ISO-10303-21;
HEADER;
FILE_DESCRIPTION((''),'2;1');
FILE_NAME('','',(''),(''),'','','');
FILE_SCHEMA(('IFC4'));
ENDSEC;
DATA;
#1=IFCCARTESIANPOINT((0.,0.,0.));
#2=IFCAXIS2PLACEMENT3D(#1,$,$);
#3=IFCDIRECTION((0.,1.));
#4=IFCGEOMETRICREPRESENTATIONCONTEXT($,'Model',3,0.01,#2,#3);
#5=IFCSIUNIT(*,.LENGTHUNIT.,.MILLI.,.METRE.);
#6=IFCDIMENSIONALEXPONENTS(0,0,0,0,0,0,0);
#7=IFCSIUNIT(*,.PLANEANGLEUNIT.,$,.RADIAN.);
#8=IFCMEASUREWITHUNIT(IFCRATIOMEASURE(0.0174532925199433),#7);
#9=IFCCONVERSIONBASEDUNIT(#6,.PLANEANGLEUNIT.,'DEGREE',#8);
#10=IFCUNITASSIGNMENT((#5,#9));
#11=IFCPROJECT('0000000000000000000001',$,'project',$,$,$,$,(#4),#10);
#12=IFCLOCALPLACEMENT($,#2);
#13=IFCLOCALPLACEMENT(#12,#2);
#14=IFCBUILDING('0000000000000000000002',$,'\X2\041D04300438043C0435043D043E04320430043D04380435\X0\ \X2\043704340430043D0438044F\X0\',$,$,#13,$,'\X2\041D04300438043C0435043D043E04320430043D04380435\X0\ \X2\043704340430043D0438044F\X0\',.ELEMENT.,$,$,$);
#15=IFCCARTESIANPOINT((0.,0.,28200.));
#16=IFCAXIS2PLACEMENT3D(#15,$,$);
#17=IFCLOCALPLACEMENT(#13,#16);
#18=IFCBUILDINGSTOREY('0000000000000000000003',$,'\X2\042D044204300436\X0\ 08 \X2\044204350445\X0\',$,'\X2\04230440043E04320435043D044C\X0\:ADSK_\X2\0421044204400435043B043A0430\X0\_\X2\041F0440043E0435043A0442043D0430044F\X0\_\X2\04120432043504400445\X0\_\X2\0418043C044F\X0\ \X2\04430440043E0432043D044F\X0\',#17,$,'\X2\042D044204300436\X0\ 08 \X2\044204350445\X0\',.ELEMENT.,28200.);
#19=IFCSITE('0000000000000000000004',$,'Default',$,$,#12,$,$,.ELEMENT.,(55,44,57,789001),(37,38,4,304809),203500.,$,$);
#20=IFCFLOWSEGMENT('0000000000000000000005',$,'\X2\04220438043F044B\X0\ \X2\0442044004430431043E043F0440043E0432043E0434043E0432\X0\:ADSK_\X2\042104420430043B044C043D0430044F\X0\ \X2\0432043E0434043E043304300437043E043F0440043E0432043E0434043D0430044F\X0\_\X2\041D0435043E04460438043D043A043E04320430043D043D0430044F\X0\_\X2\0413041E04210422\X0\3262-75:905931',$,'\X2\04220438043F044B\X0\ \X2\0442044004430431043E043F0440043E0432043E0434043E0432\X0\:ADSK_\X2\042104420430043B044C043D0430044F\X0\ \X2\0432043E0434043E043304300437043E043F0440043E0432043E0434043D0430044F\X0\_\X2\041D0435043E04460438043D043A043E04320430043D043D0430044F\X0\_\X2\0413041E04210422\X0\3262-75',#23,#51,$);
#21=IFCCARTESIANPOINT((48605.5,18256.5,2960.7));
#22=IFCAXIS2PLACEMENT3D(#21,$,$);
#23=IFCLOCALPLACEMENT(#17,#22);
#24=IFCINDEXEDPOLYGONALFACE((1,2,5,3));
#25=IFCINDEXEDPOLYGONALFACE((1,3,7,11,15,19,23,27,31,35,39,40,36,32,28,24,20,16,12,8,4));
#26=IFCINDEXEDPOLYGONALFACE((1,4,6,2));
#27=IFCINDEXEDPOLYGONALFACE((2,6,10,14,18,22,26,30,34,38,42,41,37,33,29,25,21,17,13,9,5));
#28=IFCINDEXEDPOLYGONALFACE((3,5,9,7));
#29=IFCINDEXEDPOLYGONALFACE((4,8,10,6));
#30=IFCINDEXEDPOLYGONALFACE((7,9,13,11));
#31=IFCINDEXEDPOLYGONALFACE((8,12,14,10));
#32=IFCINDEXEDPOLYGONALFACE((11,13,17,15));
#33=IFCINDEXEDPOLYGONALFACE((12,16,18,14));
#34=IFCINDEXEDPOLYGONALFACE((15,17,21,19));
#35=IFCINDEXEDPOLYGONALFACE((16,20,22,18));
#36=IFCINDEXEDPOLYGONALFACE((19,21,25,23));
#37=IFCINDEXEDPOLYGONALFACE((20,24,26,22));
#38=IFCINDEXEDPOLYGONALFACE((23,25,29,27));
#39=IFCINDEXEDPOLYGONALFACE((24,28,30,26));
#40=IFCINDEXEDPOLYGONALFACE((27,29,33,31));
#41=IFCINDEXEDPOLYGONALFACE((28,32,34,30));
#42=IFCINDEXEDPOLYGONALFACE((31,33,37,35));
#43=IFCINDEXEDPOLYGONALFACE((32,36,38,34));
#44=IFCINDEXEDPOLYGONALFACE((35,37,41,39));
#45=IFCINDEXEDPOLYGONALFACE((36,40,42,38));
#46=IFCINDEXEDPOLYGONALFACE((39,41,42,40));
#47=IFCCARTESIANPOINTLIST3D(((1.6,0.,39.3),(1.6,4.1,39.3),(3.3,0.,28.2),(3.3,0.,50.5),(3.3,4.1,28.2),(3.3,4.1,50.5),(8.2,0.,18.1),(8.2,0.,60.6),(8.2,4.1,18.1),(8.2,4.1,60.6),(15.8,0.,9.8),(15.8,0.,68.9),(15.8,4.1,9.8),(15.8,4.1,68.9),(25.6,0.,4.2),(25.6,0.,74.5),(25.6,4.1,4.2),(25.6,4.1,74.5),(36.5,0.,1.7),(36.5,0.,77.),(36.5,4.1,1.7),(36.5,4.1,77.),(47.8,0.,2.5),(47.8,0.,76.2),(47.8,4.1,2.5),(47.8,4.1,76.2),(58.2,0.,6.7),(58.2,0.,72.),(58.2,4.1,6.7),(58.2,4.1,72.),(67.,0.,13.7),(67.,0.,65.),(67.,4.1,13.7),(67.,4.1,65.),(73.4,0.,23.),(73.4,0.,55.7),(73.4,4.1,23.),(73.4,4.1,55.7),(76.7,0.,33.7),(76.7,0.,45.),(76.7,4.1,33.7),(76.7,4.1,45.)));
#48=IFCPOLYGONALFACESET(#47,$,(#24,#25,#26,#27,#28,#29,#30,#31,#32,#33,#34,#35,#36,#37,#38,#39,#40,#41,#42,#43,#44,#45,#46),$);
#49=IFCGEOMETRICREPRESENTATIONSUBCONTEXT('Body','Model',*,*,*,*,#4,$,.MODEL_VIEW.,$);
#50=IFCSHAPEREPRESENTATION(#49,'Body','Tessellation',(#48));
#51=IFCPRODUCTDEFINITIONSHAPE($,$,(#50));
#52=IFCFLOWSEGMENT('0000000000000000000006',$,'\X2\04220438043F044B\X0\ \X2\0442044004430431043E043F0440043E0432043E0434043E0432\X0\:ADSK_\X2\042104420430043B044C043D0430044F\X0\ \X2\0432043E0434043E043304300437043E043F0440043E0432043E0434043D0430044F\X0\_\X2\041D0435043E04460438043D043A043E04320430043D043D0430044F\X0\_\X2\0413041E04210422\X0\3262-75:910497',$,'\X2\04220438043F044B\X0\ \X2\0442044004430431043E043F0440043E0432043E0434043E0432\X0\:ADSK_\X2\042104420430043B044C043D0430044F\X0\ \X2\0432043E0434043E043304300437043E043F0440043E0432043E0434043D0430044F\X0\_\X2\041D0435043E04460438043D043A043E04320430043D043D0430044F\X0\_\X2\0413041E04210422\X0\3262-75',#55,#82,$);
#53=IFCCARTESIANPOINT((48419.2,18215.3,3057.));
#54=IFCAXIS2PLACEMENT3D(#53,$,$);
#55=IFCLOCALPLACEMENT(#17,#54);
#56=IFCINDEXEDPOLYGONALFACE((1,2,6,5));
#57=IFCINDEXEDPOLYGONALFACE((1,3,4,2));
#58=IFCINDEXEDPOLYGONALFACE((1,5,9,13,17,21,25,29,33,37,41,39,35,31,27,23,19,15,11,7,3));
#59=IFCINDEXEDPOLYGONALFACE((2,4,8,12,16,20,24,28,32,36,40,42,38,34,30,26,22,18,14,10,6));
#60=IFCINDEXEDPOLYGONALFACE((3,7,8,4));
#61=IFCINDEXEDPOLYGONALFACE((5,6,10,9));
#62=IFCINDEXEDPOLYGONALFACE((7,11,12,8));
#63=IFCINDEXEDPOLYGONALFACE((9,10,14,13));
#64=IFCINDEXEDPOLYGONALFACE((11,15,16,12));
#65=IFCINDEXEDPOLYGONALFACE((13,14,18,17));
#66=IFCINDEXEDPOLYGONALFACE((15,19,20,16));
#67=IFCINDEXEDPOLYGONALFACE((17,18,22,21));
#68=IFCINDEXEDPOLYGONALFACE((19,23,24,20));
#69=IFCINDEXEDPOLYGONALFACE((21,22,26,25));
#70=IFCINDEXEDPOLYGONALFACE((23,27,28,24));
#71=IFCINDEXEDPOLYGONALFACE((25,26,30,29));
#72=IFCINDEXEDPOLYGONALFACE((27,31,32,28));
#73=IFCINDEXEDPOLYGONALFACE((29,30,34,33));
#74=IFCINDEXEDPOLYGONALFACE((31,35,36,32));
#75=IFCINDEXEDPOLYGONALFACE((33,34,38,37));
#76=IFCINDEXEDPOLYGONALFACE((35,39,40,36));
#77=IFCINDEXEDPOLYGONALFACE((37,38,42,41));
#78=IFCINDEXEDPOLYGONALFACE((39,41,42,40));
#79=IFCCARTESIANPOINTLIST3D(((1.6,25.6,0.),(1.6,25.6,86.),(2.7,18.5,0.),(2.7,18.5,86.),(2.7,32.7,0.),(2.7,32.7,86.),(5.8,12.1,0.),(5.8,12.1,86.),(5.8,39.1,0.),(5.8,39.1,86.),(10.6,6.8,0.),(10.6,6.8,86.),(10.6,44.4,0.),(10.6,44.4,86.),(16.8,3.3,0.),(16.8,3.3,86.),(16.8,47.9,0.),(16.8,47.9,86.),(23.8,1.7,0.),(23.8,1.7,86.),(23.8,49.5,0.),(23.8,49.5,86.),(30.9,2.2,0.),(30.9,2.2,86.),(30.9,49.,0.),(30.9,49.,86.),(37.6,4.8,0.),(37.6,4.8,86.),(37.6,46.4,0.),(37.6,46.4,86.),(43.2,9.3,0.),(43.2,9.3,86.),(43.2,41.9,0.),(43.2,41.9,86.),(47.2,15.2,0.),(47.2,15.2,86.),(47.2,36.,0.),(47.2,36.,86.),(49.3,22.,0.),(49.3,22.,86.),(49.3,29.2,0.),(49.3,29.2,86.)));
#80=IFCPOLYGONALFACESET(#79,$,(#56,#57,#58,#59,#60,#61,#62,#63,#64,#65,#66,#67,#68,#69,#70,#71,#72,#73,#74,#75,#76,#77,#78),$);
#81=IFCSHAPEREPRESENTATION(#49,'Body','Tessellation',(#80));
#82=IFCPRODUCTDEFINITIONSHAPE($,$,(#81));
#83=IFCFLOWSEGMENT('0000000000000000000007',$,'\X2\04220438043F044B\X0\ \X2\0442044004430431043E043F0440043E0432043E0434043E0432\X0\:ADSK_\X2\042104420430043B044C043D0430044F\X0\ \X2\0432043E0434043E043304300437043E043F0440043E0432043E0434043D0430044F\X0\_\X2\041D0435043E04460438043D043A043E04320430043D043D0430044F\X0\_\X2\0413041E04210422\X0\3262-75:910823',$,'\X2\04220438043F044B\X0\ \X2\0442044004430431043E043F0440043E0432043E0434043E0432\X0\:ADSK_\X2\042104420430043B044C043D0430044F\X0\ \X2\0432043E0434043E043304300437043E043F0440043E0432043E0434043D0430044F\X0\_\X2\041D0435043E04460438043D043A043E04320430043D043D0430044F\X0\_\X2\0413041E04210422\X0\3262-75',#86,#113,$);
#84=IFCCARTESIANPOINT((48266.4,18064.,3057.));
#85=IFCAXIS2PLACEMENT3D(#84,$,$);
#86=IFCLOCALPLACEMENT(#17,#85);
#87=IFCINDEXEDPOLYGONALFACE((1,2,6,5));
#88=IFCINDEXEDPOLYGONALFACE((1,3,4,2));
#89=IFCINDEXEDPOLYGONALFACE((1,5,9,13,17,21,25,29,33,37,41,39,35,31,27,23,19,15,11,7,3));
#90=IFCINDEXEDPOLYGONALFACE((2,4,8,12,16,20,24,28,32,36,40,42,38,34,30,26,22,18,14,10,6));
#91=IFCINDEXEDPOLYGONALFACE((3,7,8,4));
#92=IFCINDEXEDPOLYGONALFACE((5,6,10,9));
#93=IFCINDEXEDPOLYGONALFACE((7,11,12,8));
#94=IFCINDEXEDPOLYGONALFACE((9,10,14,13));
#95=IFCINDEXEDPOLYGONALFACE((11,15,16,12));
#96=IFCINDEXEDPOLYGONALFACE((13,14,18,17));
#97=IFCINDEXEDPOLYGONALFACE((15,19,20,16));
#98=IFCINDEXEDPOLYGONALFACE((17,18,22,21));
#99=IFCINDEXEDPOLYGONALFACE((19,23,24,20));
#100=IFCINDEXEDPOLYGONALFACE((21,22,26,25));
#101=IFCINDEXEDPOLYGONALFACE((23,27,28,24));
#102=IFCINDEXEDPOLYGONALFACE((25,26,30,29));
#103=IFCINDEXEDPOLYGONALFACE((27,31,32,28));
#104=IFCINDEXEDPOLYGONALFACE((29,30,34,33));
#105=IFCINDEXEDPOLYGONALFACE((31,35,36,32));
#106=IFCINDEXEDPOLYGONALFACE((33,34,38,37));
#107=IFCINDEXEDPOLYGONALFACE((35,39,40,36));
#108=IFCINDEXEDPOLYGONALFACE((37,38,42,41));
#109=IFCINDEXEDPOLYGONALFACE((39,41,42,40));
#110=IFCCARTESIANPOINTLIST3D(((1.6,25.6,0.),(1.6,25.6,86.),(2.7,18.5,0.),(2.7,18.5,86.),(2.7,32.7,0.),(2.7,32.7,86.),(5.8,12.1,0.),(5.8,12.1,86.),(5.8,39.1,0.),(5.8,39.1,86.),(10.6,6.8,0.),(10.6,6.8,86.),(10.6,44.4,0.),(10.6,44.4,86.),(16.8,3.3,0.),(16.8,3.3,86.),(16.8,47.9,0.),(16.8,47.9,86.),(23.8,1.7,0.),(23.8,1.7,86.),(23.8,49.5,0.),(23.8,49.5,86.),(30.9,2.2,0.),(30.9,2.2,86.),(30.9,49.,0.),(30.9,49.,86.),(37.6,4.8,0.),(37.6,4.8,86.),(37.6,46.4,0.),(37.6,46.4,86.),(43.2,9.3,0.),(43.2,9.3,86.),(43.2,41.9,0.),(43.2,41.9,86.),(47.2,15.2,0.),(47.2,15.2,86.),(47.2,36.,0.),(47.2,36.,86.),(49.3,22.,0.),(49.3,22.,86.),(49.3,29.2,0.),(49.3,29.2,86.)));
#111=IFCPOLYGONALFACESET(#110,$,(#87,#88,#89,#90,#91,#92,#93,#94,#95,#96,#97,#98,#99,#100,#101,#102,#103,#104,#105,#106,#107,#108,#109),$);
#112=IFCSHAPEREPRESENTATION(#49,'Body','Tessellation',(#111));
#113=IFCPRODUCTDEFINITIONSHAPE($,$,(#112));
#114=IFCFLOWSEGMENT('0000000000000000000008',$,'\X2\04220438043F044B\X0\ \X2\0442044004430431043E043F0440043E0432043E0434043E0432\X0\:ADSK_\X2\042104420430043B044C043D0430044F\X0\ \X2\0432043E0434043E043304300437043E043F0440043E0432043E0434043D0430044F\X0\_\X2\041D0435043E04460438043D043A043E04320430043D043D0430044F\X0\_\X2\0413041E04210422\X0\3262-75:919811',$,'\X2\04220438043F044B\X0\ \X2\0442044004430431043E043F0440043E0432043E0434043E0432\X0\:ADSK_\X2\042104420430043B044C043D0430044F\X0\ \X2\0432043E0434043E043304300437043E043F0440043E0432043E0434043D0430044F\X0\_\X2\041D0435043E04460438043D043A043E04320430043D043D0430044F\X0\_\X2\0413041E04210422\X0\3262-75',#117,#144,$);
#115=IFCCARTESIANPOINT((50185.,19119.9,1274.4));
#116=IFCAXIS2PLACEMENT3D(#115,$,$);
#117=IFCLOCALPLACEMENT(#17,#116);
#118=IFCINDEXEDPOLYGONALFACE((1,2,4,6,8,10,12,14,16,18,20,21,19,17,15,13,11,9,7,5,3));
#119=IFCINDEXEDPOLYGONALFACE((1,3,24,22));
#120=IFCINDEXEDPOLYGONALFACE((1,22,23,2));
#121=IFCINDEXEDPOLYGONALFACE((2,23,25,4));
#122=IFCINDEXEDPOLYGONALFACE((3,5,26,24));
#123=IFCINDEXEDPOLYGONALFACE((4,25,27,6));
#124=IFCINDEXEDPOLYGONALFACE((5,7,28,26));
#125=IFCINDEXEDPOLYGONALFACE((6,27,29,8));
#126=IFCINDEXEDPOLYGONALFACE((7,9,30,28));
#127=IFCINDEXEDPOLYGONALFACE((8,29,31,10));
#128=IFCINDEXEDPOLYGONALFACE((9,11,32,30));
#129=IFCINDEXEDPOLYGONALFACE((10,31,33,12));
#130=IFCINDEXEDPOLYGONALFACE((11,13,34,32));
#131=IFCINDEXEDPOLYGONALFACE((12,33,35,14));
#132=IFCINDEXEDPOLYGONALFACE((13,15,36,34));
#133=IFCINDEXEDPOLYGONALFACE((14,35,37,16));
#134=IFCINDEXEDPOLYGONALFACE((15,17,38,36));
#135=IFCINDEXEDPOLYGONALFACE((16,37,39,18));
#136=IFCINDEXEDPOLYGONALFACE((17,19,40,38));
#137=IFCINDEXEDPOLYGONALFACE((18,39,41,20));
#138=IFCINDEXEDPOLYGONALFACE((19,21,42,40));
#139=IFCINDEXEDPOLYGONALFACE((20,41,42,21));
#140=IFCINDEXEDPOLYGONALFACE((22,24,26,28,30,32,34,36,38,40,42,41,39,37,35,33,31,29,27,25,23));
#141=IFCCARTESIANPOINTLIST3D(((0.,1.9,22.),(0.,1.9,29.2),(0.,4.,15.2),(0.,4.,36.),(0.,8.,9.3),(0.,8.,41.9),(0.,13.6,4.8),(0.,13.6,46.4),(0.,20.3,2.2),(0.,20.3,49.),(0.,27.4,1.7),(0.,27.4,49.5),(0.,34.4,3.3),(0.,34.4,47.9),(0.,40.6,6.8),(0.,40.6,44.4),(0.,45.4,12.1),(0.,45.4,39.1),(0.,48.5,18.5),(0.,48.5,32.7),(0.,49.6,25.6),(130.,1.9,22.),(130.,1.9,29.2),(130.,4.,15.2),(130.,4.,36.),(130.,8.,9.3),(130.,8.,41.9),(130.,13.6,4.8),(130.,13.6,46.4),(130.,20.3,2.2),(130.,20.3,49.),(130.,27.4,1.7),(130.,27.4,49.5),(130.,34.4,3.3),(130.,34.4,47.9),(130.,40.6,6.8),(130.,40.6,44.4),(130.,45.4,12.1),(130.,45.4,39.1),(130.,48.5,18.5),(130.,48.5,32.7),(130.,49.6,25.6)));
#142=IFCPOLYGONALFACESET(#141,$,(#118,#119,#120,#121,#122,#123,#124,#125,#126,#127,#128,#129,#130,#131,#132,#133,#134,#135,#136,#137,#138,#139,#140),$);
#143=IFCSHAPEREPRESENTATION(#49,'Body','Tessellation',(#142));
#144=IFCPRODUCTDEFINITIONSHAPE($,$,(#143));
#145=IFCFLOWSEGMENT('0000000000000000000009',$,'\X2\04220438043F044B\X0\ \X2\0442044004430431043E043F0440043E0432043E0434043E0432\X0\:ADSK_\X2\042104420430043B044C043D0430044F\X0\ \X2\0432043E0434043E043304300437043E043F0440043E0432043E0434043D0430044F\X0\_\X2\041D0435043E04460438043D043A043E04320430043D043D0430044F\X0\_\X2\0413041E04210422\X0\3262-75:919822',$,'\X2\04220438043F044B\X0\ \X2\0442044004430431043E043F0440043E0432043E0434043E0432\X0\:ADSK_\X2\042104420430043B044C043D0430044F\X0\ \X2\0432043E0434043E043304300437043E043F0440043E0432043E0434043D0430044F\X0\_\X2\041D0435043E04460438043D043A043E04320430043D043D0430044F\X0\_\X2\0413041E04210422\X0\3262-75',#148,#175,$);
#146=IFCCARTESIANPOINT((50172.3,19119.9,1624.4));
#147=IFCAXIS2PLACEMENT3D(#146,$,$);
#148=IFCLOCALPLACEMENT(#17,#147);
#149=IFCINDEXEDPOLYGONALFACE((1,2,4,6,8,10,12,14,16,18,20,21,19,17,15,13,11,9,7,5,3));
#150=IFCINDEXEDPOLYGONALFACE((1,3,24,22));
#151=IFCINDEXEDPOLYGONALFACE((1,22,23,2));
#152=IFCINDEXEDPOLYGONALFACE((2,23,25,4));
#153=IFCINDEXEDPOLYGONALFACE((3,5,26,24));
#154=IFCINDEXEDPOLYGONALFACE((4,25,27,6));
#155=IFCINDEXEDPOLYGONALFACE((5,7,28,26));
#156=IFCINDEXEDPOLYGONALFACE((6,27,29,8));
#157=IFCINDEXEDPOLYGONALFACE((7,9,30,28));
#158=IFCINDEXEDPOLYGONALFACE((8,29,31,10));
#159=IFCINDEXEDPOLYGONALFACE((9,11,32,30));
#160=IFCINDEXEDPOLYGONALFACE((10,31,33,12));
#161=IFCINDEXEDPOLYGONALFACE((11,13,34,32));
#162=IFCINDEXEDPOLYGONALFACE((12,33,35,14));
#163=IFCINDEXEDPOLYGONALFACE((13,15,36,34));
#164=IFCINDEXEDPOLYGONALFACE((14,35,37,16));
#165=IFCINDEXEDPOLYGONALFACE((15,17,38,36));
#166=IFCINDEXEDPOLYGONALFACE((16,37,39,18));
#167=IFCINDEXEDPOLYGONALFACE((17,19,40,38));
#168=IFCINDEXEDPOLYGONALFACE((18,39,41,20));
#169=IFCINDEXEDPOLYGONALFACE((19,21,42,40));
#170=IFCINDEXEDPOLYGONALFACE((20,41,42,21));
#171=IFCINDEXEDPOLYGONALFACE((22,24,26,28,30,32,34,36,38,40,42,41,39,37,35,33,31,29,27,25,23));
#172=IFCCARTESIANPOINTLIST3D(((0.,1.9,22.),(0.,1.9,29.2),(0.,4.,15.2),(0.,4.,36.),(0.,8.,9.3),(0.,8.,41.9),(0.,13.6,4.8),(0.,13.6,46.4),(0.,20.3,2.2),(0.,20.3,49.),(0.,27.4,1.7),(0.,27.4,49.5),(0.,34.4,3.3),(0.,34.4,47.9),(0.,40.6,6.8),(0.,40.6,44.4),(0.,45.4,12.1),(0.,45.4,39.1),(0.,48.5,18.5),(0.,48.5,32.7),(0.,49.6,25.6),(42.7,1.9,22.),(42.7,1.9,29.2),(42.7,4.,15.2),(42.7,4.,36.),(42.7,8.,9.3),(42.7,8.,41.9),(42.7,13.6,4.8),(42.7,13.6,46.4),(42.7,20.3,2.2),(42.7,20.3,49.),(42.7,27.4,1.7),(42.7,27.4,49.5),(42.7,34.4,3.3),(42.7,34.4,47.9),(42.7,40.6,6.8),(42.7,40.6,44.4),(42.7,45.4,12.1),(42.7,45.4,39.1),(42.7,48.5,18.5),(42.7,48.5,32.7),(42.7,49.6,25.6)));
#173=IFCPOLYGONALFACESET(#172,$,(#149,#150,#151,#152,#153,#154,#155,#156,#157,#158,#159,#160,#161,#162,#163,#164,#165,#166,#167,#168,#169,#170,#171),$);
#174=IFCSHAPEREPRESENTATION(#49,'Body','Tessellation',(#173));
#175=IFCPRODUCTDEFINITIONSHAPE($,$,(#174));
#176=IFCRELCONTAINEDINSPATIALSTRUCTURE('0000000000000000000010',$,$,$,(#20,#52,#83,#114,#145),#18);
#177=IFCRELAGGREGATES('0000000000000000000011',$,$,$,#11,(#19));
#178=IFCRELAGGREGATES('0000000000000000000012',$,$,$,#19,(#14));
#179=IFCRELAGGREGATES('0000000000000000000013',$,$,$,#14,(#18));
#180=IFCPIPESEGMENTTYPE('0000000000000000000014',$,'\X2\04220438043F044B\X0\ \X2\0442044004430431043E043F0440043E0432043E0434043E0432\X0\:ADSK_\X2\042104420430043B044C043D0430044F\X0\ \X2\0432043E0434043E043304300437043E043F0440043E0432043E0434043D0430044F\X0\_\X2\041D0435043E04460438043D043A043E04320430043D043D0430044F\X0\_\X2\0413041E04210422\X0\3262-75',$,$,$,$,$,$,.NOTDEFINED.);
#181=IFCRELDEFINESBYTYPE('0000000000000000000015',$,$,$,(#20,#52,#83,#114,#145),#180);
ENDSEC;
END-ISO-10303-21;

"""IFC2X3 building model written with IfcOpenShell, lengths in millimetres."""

from ifc_helpers import new_model, entity, si_unit, converted_unit, direction, frame, origin, origin_2d_with_axis, place, context, subcontext, project, spatial, circle, extrude, type_object, element, save


model = new_model("IFC2X3")

# Units and contexts
model_context = context("Model", 3, precision=0.01, world=origin(), true_north=direction((0.0, 1.0)))
body_context = subcontext(model_context, "Body", "Model", "MODEL_VIEW")
ifc_project = project(units=[si_unit("LENGTHUNIT", "METRE", prefix="MILLI"), converted_unit("PLANEANGLEUNIT", "DEGREE", entity("IfcRatioMeasure", 0.0174532925199433), si_unit("PLANEANGLEUNIT", "RADIAN"), dimensions=[0, 0, 0, 0, 0, 0, 0])], contexts=[model_context])

# Site, building, storey
site_placement = place(None, origin())
site = spatial("IfcSite", under=ifc_project, at=site_placement, Name="Default", CompositionType="ELEMENT", RefLatitude=(55, 44, 57, 789001), RefLongitude=(37, 38, 4, 304809), RefElevation=203500.0)
building_placement = place(site_placement, origin())
building = spatial("IfcBuilding", under=site, at=building_placement, Name="Наименование здания", LongName="Наименование здания", CompositionType="ELEMENT")
storey_placement = place(building_placement, frame((0.0, 0.0, 28200.0)))
storey = spatial("IfcBuildingStorey", under=building, at=storey_placement, Name="Этаж 08 тех", ObjectType="Уровень:ADSK_Стрелка_Проектная_Вверх_Имя уровня", LongName="Этаж 08 тех", CompositionType="ELEMENT", Elevation=28200.0)

# Flow segments
pipe_segment_type = type_object("IfcPipeSegmentType", Name="Типы трубопроводов:ADSK_Стальная водогазопроводная_Неоцинкованная_ГОСТ3262-75", PredefinedType="NOTDEFINED")
flow_segment_1_placement = place(storey_placement, frame((48605.5, 18256.5, 2960.7)))
element("IfcFlowSegment", 1, at=flow_segment_1_placement, inside=storey, type_object=pipe_segment_type, Name="Типы трубопроводов:ADSK_Стальная водогазопроводная_Неоцинкованная_ГОСТ3262-75:905931", ObjectType="Типы трубопроводов:ADSK_Стальная водогазопроводная_Неоцинкованная_ГОСТ3262-75", context=body_context, shape_type="SweptSolid", body=[
    extrude(circle(Radius=37.8, at=origin_2d_with_axis()), frame((39.4, 0.0, 39.4), z_axis=(0.0, 1.0, 0.0), x_axis=(-1.0, 0.0, 0.0)), (0.0, 0.0, 1.0), 4.1),
])
flow_segment_2_placement = place(storey_placement, frame((48419.2, 18215.3, 3057.0)))
element("IfcFlowSegment", 2, at=flow_segment_2_placement, inside=storey, type_object=pipe_segment_type, Name="Типы трубопроводов:ADSK_Стальная водогазопроводная_Неоцинкованная_ГОСТ3262-75:910497", ObjectType="Типы трубопроводов:ADSK_Стальная водогазопроводная_Неоцинкованная_ГОСТ3262-75", context=body_context, shape_type="SweptSolid", body=[
    extrude(circle(Radius=24.0, at=origin_2d_with_axis()), frame((25.6, 25.6, 0.0), z_axis=(0.0, 0.0, 1.0), x_axis=(-1.0, 0.0, 0.0)), (0.0, 0.0, 1.0), 86.0),
])
flow_segment_3_placement = place(storey_placement, frame((48266.4, 18064.0, 3057.0)))
element("IfcFlowSegment", 3, at=flow_segment_3_placement, inside=storey, type_object=pipe_segment_type, Name="Типы трубопроводов:ADSK_Стальная водогазопроводная_Неоцинкованная_ГОСТ3262-75:910823", ObjectType="Типы трубопроводов:ADSK_Стальная водогазопроводная_Неоцинкованная_ГОСТ3262-75", context=body_context, shape_type="SweptSolid", body=[
    extrude(circle(Radius=24.0, at=origin_2d_with_axis()), frame((25.6, 25.6, 0.0), z_axis=(0.0, 0.0, 1.0), x_axis=(-1.0, 0.0, 0.0)), (0.0, 0.0, 1.0), 86.0),
])
flow_segment_4_placement = place(storey_placement, frame((50185.0, 19119.9, 1274.4)))
element("IfcFlowSegment", 4, at=flow_segment_4_placement, inside=storey, type_object=pipe_segment_type, Name="Типы трубопроводов:ADSK_Стальная водогазопроводная_Неоцинкованная_ГОСТ3262-75:919811", ObjectType="Типы трубопроводов:ADSK_Стальная водогазопроводная_Неоцинкованная_ГОСТ3262-75", context=body_context, shape_type="SweptSolid", body=[
    extrude(circle(Radius=24.0, at=origin_2d_with_axis()), frame((0.0, 25.6, 25.6), z_axis=(1.0, 0.0, 0.0), x_axis=(0.0, 1.0, 0.0)), (0.0, 0.0, 1.0), 130.0),
])
flow_segment_5_placement = place(storey_placement, frame((50172.3, 19119.9, 1624.4)))
element("IfcFlowSegment", 5, at=flow_segment_5_placement, inside=storey, type_object=pipe_segment_type, Name="Типы трубопроводов:ADSK_Стальная водогазопроводная_Неоцинкованная_ГОСТ3262-75:919822", ObjectType="Типы трубопроводов:ADSK_Стальная водогазопроводная_Неоцинкованная_ГОСТ3262-75", context=body_context, shape_type="SweptSolid", body=[
    extrude(circle(Radius=24.0, at=origin_2d_with_axis()), frame((0.0, 25.6, 25.6), z_axis=(1.0, 0.0, 0.0), x_axis=(0.0, 1.0, 0.0)), (0.0, 0.0, 1.0), 42.7),
])

save(model, "model.ifc")
